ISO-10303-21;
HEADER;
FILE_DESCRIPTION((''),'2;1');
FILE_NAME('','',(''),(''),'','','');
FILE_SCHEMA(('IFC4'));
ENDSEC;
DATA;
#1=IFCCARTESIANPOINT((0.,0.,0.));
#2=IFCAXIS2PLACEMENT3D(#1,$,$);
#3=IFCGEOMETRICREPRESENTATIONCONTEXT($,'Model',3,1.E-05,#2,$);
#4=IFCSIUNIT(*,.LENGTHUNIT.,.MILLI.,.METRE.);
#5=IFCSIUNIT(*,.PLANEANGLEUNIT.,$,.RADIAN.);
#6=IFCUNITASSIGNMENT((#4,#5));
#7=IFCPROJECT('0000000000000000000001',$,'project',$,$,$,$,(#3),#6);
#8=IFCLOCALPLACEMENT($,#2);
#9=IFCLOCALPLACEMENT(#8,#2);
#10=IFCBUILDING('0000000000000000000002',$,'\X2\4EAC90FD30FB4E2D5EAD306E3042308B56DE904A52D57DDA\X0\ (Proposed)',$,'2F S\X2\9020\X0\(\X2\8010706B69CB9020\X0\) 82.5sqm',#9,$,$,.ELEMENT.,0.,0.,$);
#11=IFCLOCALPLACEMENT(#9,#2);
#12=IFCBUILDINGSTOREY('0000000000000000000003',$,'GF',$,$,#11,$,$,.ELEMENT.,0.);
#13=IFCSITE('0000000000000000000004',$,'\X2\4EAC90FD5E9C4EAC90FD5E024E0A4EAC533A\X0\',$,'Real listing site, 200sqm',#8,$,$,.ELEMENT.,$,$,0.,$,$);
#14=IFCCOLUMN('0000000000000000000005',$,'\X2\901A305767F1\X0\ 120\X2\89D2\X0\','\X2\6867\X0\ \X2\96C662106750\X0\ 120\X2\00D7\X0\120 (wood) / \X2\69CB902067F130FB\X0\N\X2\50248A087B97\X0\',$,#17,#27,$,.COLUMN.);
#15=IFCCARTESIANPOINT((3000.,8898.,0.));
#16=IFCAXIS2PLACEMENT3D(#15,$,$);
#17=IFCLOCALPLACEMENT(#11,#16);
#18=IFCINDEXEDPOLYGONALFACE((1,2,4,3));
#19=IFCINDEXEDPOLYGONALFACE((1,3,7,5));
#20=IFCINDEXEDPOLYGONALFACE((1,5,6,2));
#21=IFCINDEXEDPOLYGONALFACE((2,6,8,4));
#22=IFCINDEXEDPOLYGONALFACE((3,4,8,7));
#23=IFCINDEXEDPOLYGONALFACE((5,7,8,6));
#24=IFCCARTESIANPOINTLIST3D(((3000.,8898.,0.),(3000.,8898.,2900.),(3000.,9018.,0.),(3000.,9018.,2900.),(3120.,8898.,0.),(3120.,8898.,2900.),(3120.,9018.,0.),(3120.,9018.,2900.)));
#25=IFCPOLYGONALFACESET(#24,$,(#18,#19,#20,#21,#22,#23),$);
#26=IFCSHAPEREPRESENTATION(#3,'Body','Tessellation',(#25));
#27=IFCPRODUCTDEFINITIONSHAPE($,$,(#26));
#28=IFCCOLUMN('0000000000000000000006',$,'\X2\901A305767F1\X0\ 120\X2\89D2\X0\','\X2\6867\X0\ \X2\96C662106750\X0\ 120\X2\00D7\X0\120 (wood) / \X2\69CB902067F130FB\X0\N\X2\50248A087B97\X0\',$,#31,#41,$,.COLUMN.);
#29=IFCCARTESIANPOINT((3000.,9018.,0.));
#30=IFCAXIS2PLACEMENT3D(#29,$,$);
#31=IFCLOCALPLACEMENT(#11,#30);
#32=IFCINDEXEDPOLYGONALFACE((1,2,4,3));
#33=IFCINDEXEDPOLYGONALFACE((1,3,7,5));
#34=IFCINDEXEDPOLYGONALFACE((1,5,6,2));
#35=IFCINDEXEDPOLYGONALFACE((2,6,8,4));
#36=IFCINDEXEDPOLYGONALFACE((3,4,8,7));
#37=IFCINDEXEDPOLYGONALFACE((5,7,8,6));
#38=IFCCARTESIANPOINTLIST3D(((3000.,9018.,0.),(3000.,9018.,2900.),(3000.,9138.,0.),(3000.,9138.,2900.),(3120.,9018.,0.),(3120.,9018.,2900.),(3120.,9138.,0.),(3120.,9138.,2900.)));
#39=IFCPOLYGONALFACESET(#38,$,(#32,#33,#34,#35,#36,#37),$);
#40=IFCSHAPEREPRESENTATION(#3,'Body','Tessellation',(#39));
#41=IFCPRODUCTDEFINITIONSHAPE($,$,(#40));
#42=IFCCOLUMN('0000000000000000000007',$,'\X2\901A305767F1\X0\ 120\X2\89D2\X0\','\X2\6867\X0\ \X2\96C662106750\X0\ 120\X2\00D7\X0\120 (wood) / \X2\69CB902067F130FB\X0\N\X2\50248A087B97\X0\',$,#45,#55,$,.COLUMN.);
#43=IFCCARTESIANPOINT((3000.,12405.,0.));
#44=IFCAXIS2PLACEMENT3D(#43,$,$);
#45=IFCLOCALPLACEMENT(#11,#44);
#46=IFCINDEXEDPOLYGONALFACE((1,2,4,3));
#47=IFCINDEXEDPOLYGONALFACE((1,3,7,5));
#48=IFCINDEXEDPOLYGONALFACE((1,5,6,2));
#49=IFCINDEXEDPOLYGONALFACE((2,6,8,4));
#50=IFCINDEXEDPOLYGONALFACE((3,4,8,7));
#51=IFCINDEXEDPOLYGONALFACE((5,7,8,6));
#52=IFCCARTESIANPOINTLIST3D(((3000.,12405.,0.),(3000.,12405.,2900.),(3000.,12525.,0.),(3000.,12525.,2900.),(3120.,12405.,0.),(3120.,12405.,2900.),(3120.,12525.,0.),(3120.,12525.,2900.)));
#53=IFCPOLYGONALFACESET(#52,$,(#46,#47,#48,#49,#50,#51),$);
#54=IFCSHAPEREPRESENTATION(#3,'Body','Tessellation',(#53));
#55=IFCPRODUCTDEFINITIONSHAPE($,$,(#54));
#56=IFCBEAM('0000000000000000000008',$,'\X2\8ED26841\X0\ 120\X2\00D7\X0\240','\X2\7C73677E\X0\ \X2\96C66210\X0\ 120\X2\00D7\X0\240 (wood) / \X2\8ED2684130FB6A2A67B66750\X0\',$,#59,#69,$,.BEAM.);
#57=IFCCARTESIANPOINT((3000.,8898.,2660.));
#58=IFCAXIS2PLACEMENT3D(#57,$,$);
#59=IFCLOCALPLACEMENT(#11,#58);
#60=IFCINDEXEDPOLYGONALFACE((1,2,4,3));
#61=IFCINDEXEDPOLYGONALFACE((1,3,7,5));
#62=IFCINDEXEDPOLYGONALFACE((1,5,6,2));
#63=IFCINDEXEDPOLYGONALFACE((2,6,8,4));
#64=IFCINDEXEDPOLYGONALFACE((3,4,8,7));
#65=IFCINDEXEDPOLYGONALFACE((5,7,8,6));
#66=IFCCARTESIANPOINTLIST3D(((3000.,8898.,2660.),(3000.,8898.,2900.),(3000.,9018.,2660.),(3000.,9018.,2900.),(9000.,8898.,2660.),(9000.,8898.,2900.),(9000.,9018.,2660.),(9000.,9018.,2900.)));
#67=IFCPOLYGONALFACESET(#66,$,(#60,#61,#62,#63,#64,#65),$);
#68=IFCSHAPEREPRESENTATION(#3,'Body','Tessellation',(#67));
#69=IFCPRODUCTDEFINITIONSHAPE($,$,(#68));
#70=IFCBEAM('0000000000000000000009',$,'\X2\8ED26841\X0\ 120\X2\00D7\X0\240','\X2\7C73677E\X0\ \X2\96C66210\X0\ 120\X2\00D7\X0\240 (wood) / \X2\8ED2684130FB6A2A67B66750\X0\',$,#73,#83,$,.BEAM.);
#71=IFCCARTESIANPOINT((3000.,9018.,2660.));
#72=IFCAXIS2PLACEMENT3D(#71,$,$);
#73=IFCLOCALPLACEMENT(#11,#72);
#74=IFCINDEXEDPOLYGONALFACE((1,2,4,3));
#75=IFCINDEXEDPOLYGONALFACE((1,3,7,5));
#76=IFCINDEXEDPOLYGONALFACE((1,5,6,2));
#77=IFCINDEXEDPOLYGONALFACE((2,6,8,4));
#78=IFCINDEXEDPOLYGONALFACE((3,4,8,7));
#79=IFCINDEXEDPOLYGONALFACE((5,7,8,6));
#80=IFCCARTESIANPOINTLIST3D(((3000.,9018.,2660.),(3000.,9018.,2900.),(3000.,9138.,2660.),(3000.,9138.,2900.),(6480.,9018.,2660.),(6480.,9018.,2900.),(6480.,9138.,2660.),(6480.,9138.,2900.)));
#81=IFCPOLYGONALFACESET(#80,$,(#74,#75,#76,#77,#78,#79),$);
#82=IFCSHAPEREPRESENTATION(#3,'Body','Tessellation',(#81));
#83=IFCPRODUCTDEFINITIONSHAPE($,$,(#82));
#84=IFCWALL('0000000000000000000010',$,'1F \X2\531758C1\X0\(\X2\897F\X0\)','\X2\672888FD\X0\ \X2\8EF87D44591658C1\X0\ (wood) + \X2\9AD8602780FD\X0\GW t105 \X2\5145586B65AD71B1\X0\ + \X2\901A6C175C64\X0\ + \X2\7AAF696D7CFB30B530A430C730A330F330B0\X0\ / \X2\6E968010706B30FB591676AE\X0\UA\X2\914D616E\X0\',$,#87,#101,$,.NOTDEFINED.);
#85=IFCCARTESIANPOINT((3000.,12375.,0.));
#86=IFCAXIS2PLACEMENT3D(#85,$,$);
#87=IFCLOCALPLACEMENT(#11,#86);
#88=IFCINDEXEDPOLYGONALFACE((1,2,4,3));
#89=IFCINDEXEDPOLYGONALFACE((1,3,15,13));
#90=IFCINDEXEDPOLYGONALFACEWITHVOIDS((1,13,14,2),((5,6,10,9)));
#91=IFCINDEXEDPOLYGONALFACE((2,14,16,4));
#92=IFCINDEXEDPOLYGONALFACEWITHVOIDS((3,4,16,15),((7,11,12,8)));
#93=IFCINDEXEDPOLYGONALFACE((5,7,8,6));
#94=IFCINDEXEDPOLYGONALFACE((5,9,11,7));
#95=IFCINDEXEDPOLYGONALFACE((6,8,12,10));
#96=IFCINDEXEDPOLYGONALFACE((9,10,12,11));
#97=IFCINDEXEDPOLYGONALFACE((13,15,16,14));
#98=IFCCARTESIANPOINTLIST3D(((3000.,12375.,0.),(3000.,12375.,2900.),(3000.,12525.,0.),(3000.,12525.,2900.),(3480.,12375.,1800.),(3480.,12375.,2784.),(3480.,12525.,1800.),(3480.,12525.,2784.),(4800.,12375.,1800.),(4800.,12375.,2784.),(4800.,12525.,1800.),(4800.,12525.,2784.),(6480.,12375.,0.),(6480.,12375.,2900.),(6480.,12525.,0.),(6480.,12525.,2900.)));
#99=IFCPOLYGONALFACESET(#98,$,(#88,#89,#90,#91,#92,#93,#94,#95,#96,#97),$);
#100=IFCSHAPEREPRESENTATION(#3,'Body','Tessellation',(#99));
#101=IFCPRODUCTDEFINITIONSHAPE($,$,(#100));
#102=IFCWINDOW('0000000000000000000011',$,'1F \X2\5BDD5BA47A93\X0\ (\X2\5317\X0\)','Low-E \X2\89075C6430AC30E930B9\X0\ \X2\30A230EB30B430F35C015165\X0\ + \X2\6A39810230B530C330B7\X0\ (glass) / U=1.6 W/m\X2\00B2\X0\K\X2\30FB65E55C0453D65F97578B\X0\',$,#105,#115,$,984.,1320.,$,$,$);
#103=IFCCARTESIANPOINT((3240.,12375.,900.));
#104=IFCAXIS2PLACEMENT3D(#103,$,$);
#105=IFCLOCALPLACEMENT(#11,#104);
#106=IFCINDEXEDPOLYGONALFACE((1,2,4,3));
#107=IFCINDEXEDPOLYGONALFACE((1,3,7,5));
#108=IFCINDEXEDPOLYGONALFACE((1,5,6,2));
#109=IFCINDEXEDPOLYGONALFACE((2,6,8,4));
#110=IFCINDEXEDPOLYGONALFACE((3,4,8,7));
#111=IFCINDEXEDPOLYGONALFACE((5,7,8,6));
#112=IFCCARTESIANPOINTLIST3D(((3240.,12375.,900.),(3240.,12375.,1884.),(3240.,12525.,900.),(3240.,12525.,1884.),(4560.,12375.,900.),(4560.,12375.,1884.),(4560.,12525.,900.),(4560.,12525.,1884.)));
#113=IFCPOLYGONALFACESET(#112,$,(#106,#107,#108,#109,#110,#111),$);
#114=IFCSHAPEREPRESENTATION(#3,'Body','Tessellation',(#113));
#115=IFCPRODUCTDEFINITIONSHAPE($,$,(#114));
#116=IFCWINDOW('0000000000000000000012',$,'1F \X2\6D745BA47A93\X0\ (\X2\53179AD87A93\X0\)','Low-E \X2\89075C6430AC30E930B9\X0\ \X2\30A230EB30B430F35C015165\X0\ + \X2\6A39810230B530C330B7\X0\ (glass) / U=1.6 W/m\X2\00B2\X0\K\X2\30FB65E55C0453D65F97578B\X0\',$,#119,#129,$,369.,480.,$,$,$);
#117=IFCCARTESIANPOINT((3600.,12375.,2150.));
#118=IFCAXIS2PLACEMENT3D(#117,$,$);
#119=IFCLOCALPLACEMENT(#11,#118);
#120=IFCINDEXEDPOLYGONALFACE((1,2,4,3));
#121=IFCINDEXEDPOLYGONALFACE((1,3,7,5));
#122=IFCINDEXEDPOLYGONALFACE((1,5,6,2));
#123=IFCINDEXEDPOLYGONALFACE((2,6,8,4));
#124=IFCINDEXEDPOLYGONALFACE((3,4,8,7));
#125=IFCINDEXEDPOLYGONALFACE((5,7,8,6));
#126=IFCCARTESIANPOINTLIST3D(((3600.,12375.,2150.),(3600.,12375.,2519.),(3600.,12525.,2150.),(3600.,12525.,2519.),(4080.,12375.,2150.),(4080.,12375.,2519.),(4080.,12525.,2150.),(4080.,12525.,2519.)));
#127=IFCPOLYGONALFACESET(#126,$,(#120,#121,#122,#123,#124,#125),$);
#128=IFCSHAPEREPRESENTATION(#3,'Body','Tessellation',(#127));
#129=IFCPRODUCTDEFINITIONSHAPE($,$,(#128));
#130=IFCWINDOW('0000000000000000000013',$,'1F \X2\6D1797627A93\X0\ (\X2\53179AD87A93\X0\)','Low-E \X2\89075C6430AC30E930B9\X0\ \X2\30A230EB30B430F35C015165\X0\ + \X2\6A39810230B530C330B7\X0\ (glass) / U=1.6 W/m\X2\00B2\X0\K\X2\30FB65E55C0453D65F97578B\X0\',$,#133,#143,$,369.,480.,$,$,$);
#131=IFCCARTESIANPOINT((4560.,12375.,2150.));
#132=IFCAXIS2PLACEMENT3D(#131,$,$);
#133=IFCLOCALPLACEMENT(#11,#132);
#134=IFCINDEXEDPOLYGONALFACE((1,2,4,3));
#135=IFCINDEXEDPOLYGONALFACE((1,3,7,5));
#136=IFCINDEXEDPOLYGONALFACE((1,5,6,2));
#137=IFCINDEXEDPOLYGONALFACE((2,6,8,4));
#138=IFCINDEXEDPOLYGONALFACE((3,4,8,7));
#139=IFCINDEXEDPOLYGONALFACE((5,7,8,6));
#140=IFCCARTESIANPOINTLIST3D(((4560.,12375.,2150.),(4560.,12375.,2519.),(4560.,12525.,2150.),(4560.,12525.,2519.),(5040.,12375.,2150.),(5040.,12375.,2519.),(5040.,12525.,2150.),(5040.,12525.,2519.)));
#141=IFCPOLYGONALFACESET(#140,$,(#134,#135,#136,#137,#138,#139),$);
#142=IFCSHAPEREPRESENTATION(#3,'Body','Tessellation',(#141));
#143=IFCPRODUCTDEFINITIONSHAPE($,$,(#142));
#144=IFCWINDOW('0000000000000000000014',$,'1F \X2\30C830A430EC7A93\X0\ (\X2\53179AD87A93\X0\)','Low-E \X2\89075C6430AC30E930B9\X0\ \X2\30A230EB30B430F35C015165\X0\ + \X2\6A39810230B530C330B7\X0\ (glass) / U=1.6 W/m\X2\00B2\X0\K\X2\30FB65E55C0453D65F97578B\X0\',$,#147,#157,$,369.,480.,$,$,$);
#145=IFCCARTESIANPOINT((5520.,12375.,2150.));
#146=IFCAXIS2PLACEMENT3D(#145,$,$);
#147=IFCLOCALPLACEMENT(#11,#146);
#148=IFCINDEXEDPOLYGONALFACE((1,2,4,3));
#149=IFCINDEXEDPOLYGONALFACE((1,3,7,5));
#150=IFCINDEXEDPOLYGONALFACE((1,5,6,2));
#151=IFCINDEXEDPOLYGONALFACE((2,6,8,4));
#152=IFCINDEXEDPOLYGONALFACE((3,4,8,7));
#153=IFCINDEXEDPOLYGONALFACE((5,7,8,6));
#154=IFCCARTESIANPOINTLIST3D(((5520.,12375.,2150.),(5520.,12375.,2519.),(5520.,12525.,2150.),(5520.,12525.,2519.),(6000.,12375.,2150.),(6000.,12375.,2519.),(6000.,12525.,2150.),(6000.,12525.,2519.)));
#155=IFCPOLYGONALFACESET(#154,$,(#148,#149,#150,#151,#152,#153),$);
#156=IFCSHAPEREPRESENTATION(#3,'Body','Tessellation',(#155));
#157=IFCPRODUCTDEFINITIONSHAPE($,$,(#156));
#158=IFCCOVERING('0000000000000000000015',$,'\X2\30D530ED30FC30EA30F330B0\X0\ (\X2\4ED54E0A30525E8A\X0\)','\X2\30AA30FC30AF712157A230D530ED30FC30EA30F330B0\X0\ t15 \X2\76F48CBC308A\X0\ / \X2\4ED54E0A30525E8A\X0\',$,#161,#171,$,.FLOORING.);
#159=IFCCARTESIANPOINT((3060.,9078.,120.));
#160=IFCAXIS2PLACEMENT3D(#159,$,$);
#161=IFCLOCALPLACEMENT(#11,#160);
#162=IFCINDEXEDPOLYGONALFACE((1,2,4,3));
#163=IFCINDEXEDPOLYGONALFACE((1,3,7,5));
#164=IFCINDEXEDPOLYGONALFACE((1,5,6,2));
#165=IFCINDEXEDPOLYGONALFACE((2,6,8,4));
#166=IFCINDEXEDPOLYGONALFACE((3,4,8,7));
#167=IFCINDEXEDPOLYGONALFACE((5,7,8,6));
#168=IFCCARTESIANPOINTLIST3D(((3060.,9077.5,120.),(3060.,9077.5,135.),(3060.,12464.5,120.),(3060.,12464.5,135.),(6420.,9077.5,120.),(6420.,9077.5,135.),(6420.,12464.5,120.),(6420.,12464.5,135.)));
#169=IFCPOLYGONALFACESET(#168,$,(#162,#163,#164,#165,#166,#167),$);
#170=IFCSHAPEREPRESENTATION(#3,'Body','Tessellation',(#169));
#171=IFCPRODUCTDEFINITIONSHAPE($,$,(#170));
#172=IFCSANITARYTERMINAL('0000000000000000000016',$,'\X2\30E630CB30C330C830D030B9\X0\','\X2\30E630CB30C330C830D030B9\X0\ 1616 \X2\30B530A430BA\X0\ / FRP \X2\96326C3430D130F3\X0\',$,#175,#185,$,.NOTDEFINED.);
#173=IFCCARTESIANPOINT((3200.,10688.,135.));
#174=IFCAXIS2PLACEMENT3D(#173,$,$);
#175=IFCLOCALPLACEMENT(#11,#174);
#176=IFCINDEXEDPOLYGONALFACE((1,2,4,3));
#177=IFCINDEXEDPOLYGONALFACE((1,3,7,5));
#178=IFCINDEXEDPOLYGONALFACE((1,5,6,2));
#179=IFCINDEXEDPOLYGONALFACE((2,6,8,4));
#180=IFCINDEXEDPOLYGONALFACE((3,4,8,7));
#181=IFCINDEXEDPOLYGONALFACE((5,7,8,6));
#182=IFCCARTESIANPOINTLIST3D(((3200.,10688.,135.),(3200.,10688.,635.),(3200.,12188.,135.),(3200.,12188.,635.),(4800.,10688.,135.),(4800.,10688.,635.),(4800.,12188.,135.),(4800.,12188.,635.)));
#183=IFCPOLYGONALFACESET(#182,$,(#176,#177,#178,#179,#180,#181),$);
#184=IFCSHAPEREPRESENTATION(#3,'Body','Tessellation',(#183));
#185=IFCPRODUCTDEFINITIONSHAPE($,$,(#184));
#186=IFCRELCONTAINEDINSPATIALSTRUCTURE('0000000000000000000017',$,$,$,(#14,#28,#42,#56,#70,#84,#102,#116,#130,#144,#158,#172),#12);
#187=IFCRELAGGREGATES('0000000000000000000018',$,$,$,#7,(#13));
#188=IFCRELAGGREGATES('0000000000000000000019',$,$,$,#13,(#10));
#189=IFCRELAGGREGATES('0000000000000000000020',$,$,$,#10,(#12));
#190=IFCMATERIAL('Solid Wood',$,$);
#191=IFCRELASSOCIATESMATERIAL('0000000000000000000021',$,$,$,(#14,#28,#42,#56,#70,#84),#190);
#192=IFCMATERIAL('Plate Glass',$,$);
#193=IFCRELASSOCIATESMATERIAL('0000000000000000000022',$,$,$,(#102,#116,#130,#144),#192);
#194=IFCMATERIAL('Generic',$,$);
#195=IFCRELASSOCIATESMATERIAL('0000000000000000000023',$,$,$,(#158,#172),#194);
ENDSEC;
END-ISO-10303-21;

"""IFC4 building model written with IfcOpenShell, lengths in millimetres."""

from ifc_helpers import new_model, si_unit, frame, frame_2d, origin, place, context, project, spatial, rectangle, extrude, material, element, fill, save


model = new_model("IFC4")

# Units and contexts
model_context = context("Model", 3, precision=1e-05, world=origin())
ifc_project = project(units=[si_unit("LENGTHUNIT", "METRE", prefix="MILLI"), si_unit("PLANEANGLEUNIT", "RADIAN")], contexts=[model_context])

# Site, building, storey
site_placement = place(None, origin())
site = spatial("IfcSite", under=ifc_project, at=site_placement, Name="京都府京都市上京区", ObjectType="Real listing site, 200sqm", CompositionType="ELEMENT", RefElevation=0.0)
building_placement = place(site_placement, origin())
building = spatial("IfcBuilding", under=site, at=building_placement, Name="京都・中庭のある回遊動線 (Proposed)", ObjectType="2F S造(耐火構造) 82.5sqm", CompositionType="ELEMENT", ElevationOfRefHeight=0.0, ElevationOfTerrain=0.0)
storey_placement = place(building_placement, origin())
storey = spatial("IfcBuildingStorey", under=building, at=storey_placement, Name="GF", CompositionType="ELEMENT", Elevation=0.0)

# Columns
ifc_material_1 = material(Name="Solid Wood")
column_1_placement = place(storey_placement, frame((3000.0, 8898.0, 0.0)))
element("IfcColumn", 1, at=column_1_placement, inside=storey, material=ifc_material_1, Name="通し柱 120角", Description="桧 集成材 120×120 (wood) / 構造柱・N値計算", PredefinedType="COLUMN", context=model_context, shape_type="SweptSolid", body=[
    extrude(rectangle(XDim=120.0, YDim=120.0, at=frame_2d((60.0, 60.0))), frame((3000.0, 8898.0, 0.0)), (0.0, 0.0, 1.0), 2900.0),
])
column_2_placement = place(storey_placement, frame((3000.0, 9018.0, 0.0)))
element("IfcColumn", 2, at=column_2_placement, inside=storey, material=ifc_material_1, Name="通し柱 120角", Description="桧 集成材 120×120 (wood) / 構造柱・N値計算", PredefinedType="COLUMN", context=model_context, shape_type="SweptSolid", body=[
    extrude(rectangle(XDim=120.0, YDim=120.0, at=frame_2d((60.0, 60.0))), frame((3000.0, 9018.0, 0.0)), (0.0, 0.0, 1.0), 2900.0),
])
column_3_placement = place(storey_placement, frame((3000.0, 12405.0, 0.0)))
element("IfcColumn", 3, at=column_3_placement, inside=storey, material=ifc_material_1, Name="通し柱 120角", Description="桧 集成材 120×120 (wood) / 構造柱・N値計算", PredefinedType="COLUMN", context=model_context, shape_type="SweptSolid", body=[
    extrude(rectangle(XDim=120.0, YDim=120.0, at=frame_2d((60.0, 60.0))), frame((3000.0, 12405.0, 0.0)), (0.0, 0.0, 1.0), 2900.0),
])

# Beams
beam_1_placement = place(storey_placement, frame((3000.0, 8898.0, 2660.0)))
element("IfcBeam", 4, at=beam_1_placement, inside=storey, material=ifc_material_1, Name="軒桁 120×240", Description="米松 集成 120×240 (wood) / 軒桁・横架材", PredefinedType="BEAM", context=model_context, shape_type="SweptSolid", body=[
    extrude(rectangle(XDim=6000.0, YDim=120.0, at=frame_2d((3000.0, 60.0))), frame((3000.0, 8898.0, 2660.0)), (0.0, 0.0, 1.0), 240.0),
])
beam_2_placement = place(storey_placement, frame((3000.0, 9018.0, 2660.0)))
element("IfcBeam", 5, at=beam_2_placement, inside=storey, material=ifc_material_1, Name="軒桁 120×240", Description="米松 集成 120×240 (wood) / 軒桁・横架材", PredefinedType="BEAM", context=model_context, shape_type="SweptSolid", body=[
    extrude(rectangle(XDim=3480.0, YDim=120.0, at=frame_2d((1740.0, 60.0))), frame((3000.0, 9018.0, 2660.0)), (0.0, 0.0, 1.0), 240.0),
])

# Wall, openings, windows
wall_1_placement = place(storey_placement, frame((3000.0, 12375.0, 0.0)))
wall_1 = element("IfcWall", 6, at=wall_1_placement, inside=storey, material=ifc_material_1, Name="1F 北壁(西)", Description="木製 軸組外壁 (wood) + 高性能GW t105 充填断熱 + 通気層 + 窯業系サイディング / 準耐火・外皮UA配慮", PredefinedType="NOTDEFINED", context=model_context, shape_type="SweptSolid", body=[
    extrude(rectangle(XDim=3480.0, YDim=150.0, at=frame_2d((1740.0, 75.0))), frame((3000.0, 12375.0, 0.0)), (0.0, 0.0, 1.0), 2900.0),
])
opening_1_placement = place(storey_placement, frame((3240.0, 12375.0, 900.0)))
opening_1 = element("IfcOpeningElement", 7, at=opening_1_placement, cuts=wall_1, PredefinedType="NOTDEFINED", context=model_context, shape_type="SweptSolid", body=[
    extrude(rectangle(XDim=1320.0, YDim=150.0, at=frame_2d((660.0, 75.0))), frame((3240.0, 12375.0, 900.0)), (0.0, 0.0, 1.0), 984.0),
])
opening_2_placement = place(storey_placement, frame((3600.0, 12375.0, 2150.0)))
opening_2 = element("IfcOpeningElement", 8, at=opening_2_placement, cuts=wall_1, PredefinedType="NOTDEFINED", context=model_context, shape_type="SweptSolid", body=[
    extrude(rectangle(XDim=480.0, YDim=150.0, at=frame_2d((240.0, 75.0))), frame((3600.0, 12375.0, 2150.0)), (0.0, 0.0, 1.0), 369.0),
])
opening_3_placement = place(storey_placement, frame((4560.0, 12375.0, 2150.0)))
opening_3 = element("IfcOpeningElement", 9, at=opening_3_placement, cuts=wall_1, PredefinedType="NOTDEFINED", context=model_context, shape_type="SweptSolid", body=[
    extrude(rectangle(XDim=480.0, YDim=150.0, at=frame_2d((240.0, 75.0))), frame((4560.0, 12375.0, 2150.0)), (0.0, 0.0, 1.0), 369.0),
])
opening_4_placement = place(storey_placement, frame((5520.0, 12375.0, 2150.0)))
opening_4 = element("IfcOpeningElement", 10, at=opening_4_placement, cuts=wall_1, PredefinedType="NOTDEFINED", context=model_context, shape_type="SweptSolid", body=[
    extrude(rectangle(XDim=480.0, YDim=150.0, at=frame_2d((240.0, 75.0))), frame((5520.0, 12375.0, 2150.0)), (0.0, 0.0, 1.0), 369.0),
])
ifc_material_2 = material(Name="Plate Glass")
window_1_placement = place(storey_placement, frame((3240.0, 12375.0, 900.0)))
window_1 = element("IfcWindow", 11, at=window_1_placement, inside=storey, material=ifc_material_2, Name="1F 寝室窓 (北)", Description="Low-E 複層ガラス アルゴン封入 + 樹脂サッシ (glass) / U=1.6 W/m²K・日射取得型", OverallHeight=984.0, OverallWidth=1320.0, context=model_context, shape_type="SweptSolid", body=[
    extrude(rectangle(XDim=1320.0, YDim=150.0, at=frame_2d((660.0, 75.0))), frame((3240.0, 12375.0, 900.0)), (0.0, 0.0, 1.0), 984.0),
])
fill(opening_1, window_1)
window_2_placement = place(storey_placement, frame((3600.0, 12375.0, 2150.0)))
window_2 = element("IfcWindow", 12, at=window_2_placement, inside=storey, material=ifc_material_2, Name="1F 浴室窓 (北高窓)", Description="Low-E 複層ガラス アルゴン封入 + 樹脂サッシ (glass) / U=1.6 W/m²K・日射取得型", OverallHeight=369.0, OverallWidth=480.0, context=model_context, shape_type="SweptSolid", body=[
    extrude(rectangle(XDim=480.0, YDim=150.0, at=frame_2d((240.0, 75.0))), frame((3600.0, 12375.0, 2150.0)), (0.0, 0.0, 1.0), 369.0),
])
fill(opening_2, window_2)
window_3_placement = place(storey_placement, frame((4560.0, 12375.0, 2150.0)))
window_3 = element("IfcWindow", 13, at=window_3_placement, inside=storey, material=ifc_material_2, Name="1F 洗面窓 (北高窓)", Description="Low-E 複層ガラス アルゴン封入 + 樹脂サッシ (glass) / U=1.6 W/m²K・日射取得型", OverallHeight=369.0, OverallWidth=480.0, context=model_context, shape_type="SweptSolid", body=[
    extrude(rectangle(XDim=480.0, YDim=150.0, at=frame_2d((240.0, 75.0))), frame((4560.0, 12375.0, 2150.0)), (0.0, 0.0, 1.0), 369.0),
])
fill(opening_3, window_3)
window_4_placement = place(storey_placement, frame((5520.0, 12375.0, 2150.0)))
window_4 = element("IfcWindow", 14, at=window_4_placement, inside=storey, material=ifc_material_2, Name="1F トイレ窓 (北高窓)", Description="Low-E 複層ガラス アルゴン封入 + 樹脂サッシ (glass) / U=1.6 W/m²K・日射取得型", OverallHeight=369.0, OverallWidth=480.0, context=model_context, shape_type="SweptSolid", body=[
    extrude(rectangle(XDim=480.0, YDim=150.0, at=frame_2d((240.0, 75.0))), frame((5520.0, 12375.0, 2150.0)), (0.0, 0.0, 1.0), 369.0),
])
fill(opening_4, window_4)

# Covering
ifc_material_3 = material(Name="Generic")
covering_placement = place(storey_placement, frame((3060.0, 9078.0, 120.0)))
element("IfcCovering", 15, at=covering_placement, inside=storey, material=ifc_material_3, Name="フローリング (仕上げ床)", Description="オーク無垢フローリング t15 直貼り / 仕上げ床", PredefinedType="FLOORING", context=model_context, shape_type="SweptSolid", body=[
    extrude(rectangle(XDim=3360.0, YDim=3387.0, at=frame_2d((1680.0, 1693.0))), frame((3060.0, 9078.0, 120.0)), (0.0, 0.0, 1.0), 15.0),
])

# Sanitary terminal
sanitary_terminal_placement = place(storey_placement, frame((3200.0, 10688.0, 135.0)))
element("IfcSanitaryTerminal", 16, at=sanitary_terminal_placement, inside=storey, material=ifc_material_3, Name="ユニットバス", Description="ユニットバス 1616 サイズ / FRP 防水パン", PredefinedType="NOTDEFINED", context=model_context, shape_type="SweptSolid", body=[
    extrude(rectangle(XDim=1600.0, YDim=1500.0, at=frame_2d((800.0, 750.0))), frame((3200.0, 10688.0, 135.0)), (0.0, 0.0, 1.0), 500.0),
])

save(model, "model.ifc")
